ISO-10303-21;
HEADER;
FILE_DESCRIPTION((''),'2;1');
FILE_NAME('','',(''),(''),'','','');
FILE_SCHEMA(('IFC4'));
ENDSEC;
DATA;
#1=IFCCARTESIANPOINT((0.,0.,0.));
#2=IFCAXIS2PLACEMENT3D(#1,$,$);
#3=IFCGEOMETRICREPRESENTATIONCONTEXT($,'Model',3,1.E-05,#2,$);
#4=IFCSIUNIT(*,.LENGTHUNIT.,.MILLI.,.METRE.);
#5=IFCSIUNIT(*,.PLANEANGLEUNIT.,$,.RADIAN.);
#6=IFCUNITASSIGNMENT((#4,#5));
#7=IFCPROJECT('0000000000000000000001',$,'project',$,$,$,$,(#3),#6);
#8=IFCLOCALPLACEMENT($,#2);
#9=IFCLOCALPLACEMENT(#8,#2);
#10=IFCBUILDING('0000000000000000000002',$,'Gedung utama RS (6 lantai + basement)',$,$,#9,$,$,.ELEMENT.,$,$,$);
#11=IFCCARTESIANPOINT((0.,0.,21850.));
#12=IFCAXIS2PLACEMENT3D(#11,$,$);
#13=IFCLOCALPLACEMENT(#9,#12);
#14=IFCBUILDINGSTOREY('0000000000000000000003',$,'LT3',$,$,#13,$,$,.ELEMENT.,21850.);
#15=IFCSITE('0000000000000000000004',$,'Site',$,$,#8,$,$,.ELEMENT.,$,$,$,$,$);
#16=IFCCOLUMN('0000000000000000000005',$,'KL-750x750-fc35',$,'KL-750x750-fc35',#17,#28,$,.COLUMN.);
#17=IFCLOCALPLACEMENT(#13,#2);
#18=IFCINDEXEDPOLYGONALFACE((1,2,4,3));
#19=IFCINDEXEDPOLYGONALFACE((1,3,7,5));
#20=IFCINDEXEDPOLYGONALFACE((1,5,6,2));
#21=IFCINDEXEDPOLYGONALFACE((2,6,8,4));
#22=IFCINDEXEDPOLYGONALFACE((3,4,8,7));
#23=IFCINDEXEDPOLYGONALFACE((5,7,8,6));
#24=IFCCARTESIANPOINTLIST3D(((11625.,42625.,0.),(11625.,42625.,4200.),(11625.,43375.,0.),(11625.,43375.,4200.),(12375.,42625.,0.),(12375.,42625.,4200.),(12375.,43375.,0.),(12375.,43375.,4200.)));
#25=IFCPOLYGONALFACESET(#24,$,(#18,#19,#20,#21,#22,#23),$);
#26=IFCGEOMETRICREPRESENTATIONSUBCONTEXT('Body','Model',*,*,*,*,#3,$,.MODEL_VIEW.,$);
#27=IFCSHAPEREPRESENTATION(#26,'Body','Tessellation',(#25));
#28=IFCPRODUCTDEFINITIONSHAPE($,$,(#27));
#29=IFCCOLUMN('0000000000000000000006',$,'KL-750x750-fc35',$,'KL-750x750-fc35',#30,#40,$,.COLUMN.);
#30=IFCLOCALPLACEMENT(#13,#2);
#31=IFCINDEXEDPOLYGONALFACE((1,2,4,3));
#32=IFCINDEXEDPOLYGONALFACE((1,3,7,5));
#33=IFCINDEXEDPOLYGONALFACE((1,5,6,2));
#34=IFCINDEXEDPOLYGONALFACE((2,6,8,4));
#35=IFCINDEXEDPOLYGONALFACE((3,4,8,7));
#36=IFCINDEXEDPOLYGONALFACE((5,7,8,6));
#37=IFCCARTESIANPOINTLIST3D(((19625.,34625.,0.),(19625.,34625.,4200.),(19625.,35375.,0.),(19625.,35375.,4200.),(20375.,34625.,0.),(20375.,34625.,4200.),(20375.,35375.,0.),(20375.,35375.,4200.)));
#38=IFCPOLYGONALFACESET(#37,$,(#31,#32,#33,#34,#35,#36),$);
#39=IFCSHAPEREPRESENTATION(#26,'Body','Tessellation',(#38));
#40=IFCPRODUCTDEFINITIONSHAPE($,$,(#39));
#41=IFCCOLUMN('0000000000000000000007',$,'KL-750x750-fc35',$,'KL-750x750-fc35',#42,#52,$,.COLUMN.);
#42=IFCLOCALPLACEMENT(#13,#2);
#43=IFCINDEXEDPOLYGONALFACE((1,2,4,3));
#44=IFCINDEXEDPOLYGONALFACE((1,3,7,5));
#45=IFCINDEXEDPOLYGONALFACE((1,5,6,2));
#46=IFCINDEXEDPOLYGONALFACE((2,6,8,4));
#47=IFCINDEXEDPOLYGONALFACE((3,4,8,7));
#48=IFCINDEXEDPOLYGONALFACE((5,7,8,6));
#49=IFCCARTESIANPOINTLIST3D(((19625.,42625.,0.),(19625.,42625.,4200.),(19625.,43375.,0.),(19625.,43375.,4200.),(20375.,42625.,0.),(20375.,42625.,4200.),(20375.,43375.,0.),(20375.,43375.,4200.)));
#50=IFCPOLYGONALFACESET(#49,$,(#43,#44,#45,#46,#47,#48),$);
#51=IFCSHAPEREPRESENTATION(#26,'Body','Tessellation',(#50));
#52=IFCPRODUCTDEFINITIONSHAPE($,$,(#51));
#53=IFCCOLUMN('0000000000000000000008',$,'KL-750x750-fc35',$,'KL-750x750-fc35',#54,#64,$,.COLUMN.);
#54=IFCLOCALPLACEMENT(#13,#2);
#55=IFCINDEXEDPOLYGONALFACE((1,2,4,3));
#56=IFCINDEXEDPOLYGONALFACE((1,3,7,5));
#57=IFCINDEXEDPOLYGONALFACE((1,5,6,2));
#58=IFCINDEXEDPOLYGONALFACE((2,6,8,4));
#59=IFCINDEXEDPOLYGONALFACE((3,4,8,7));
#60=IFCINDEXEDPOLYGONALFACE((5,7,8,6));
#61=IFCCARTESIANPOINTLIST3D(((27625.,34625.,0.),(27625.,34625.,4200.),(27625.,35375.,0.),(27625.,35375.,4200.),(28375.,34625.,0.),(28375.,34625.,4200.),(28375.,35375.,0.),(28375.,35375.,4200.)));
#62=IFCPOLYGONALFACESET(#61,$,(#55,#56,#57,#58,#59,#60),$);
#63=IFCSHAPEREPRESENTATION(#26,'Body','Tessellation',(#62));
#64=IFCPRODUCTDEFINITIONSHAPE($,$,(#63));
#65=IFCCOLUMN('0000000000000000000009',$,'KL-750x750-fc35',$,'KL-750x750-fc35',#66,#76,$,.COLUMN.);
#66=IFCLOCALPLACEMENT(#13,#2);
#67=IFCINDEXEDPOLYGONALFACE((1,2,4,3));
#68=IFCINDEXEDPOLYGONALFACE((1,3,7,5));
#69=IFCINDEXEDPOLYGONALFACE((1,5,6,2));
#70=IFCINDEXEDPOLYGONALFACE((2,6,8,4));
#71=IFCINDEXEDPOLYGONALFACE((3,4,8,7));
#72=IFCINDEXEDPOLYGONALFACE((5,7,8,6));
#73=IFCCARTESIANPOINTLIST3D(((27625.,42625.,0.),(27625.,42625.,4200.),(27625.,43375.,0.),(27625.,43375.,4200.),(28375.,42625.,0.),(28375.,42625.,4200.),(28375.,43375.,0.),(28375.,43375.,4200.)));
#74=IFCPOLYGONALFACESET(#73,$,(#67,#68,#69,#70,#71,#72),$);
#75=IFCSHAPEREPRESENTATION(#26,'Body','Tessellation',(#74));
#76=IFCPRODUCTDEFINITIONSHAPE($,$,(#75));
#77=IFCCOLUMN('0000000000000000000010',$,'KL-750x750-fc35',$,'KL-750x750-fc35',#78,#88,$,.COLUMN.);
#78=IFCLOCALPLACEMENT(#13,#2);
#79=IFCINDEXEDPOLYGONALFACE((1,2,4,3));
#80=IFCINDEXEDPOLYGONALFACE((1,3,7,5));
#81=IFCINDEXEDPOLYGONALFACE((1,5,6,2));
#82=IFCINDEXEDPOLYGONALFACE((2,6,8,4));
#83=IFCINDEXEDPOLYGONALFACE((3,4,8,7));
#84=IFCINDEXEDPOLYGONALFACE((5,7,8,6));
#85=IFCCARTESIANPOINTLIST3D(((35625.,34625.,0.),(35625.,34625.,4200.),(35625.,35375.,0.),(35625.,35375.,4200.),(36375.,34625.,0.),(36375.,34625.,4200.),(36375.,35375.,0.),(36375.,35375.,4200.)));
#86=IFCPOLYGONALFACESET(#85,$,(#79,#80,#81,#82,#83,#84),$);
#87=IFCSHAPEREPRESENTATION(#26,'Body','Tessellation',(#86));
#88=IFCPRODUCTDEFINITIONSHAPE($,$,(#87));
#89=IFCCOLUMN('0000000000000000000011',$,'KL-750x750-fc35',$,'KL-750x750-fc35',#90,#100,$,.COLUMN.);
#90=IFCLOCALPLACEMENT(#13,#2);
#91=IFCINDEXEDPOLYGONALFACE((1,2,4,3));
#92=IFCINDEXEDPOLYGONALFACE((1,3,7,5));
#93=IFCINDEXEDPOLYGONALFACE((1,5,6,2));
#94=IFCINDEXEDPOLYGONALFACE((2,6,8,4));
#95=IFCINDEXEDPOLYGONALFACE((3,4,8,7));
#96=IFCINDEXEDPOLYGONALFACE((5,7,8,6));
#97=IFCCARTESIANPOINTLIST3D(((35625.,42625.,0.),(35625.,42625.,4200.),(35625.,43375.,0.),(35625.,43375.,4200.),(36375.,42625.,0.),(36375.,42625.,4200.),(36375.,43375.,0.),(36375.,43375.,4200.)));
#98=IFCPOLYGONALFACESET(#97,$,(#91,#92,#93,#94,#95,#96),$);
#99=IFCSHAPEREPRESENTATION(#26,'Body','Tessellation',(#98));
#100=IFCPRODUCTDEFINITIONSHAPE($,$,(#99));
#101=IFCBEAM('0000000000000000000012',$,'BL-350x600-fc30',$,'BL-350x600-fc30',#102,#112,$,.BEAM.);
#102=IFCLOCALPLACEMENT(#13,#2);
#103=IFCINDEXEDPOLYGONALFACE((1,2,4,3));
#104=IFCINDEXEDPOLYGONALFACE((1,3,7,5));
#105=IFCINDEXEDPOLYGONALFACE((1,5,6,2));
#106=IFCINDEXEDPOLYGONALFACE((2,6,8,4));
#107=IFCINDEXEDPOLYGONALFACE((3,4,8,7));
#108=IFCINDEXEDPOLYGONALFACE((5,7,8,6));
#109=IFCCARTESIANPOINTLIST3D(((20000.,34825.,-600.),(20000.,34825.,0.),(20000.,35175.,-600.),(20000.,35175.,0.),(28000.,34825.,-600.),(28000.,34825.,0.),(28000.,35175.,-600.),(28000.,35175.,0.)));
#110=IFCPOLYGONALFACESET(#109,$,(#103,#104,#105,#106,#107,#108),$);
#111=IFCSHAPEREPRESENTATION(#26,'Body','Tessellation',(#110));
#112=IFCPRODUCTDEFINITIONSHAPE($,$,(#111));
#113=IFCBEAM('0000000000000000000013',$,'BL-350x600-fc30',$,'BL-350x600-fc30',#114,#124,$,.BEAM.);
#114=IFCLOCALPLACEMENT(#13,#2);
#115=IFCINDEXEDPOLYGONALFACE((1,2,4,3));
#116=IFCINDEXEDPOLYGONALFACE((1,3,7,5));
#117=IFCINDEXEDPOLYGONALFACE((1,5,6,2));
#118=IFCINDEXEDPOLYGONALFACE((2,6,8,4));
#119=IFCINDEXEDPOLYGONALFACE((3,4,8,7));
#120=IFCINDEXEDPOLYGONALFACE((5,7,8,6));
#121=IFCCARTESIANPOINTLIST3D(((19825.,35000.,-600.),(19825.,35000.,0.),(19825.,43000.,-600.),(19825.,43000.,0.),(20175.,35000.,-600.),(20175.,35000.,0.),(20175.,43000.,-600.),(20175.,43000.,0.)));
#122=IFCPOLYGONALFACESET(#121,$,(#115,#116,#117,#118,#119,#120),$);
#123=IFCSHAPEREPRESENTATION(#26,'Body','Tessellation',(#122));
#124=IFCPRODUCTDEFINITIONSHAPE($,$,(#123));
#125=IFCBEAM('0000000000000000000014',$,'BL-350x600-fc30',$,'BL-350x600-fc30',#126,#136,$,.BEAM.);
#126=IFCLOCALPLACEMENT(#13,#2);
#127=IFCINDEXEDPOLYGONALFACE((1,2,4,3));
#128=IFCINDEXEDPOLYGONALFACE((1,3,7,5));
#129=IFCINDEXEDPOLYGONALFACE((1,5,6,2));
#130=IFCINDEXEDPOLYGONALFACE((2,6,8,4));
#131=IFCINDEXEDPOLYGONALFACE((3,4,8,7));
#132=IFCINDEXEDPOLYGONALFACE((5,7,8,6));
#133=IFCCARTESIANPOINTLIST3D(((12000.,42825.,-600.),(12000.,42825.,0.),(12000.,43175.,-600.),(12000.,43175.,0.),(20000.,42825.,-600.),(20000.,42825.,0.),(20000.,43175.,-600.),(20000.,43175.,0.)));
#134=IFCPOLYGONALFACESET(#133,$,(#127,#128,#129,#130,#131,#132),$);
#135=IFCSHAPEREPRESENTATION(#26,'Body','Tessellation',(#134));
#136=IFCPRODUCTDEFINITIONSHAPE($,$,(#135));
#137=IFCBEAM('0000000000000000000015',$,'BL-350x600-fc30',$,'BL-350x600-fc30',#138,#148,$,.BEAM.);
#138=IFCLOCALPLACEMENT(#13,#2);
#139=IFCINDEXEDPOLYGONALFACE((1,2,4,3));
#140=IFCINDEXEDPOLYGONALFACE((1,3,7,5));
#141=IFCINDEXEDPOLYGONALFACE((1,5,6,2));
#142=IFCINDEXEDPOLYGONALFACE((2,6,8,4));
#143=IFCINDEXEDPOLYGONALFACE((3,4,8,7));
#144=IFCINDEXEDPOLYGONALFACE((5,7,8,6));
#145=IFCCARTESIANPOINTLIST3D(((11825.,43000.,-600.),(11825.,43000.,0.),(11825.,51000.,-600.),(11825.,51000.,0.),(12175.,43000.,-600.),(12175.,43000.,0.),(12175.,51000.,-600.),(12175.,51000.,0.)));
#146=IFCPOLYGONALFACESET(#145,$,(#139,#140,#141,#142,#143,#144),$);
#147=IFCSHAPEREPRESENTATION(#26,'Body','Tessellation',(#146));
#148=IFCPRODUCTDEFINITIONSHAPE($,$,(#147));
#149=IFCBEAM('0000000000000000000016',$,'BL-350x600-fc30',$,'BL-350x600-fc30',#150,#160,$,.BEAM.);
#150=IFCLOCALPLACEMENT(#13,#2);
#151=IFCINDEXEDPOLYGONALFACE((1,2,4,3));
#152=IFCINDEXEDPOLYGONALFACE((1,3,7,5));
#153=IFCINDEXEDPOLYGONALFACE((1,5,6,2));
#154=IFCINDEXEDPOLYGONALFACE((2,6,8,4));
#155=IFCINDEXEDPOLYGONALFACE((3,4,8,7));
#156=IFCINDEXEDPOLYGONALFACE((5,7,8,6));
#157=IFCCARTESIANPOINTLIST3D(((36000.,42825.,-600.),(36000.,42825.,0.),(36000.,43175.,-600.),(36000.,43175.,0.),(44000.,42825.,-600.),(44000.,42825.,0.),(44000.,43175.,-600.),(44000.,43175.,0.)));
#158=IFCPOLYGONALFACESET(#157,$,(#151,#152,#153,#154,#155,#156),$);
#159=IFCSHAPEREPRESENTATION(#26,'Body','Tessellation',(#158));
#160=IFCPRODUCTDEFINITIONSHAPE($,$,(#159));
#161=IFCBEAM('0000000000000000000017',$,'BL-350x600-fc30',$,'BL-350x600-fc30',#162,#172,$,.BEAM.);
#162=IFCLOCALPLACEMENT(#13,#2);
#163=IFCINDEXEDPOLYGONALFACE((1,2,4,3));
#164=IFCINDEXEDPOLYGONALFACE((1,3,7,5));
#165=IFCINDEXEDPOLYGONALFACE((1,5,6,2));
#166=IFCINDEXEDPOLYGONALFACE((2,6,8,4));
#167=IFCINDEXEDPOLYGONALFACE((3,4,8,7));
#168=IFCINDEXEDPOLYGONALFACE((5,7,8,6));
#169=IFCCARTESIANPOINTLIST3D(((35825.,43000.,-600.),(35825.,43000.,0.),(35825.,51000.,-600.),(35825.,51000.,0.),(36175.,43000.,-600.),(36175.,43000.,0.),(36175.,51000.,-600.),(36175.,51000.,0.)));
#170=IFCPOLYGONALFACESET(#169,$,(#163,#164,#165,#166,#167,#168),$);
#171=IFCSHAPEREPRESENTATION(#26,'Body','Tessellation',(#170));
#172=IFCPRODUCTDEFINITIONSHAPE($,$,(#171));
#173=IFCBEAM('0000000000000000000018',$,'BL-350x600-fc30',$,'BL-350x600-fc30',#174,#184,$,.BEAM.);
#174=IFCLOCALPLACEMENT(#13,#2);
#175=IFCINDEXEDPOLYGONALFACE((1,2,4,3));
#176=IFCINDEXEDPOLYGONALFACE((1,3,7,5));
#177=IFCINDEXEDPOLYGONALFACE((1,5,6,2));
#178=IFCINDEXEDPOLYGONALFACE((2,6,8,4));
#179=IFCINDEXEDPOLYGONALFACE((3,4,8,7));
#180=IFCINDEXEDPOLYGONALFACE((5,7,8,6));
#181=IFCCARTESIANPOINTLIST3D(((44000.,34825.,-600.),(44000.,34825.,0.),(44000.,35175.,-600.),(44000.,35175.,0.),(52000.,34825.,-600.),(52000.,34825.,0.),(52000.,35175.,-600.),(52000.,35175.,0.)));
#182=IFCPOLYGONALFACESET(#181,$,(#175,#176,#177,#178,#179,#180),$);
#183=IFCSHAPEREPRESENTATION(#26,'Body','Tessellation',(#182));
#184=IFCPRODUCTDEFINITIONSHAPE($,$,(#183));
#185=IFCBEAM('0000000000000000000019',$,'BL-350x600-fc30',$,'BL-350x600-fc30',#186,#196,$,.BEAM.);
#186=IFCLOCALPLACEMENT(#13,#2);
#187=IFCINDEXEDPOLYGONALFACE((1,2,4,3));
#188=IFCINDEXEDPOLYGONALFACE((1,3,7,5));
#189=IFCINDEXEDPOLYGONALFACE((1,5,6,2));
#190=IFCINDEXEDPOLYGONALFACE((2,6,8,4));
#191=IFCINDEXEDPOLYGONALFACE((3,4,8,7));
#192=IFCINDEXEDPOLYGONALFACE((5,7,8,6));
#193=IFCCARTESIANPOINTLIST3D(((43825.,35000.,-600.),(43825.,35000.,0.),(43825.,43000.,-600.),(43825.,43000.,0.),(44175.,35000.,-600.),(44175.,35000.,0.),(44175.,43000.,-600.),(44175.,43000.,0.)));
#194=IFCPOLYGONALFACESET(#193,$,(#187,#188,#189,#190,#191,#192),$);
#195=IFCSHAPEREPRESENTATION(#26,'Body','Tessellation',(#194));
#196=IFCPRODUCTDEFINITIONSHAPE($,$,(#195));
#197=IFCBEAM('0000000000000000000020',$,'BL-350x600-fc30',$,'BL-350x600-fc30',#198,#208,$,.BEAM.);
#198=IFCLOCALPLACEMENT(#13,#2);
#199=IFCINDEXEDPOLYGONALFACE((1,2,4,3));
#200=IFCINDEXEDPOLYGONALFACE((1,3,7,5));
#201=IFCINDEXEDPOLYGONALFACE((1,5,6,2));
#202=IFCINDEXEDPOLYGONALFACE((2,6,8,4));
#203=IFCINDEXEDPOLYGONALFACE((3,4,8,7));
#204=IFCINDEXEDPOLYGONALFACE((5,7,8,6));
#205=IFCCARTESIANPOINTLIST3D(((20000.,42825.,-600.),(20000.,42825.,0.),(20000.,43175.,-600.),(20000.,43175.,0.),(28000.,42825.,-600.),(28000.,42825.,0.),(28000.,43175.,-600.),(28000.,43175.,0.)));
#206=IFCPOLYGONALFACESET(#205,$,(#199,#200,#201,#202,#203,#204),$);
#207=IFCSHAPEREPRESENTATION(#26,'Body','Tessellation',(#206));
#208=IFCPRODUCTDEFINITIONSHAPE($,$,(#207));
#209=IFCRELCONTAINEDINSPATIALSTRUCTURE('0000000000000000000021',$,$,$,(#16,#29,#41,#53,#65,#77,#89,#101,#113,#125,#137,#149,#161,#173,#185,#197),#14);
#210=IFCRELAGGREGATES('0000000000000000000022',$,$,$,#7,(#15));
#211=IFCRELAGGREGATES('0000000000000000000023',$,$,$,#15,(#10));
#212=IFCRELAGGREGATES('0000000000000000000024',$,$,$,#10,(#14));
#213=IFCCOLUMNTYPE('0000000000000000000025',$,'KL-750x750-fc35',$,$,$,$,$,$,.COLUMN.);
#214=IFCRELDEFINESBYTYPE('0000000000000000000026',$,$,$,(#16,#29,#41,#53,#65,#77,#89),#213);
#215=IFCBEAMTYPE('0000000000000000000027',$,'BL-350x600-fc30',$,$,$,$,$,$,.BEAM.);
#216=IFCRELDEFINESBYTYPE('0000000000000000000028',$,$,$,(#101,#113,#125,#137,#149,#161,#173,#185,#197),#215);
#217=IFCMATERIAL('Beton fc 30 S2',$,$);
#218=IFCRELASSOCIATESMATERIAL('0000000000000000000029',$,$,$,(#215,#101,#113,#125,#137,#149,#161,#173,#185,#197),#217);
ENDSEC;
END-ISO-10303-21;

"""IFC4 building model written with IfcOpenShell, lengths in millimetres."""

from ifc_helpers import new_model, si_unit, frame, origin, origin_2d, place, context, subcontext, project, spatial, rectangle, extrude, material, material_profile, profile_set, profile_usage, type_object, element, save


model = new_model("IFC4")

# Units and contexts
model_context = context("Model", 3, precision=1e-05, world=origin())
body_context = subcontext(model_context, "Body", "Model", "MODEL_VIEW")
ifc_project = project(units=[si_unit("LENGTHUNIT", "METRE", prefix="MILLI"), si_unit("PLANEANGLEUNIT", "RADIAN")], contexts=[model_context])

# Site, building, storey
site_placement = place(None, origin())
site = spatial("IfcSite", under=ifc_project, at=site_placement, Name="Site", CompositionType="ELEMENT")
building_placement = place(site_placement, origin())
building = spatial("IfcBuilding", under=site, at=building_placement, Name="Gedung utama RS (6 lantai + basement)", CompositionType="ELEMENT")
storey_placement = place(building_placement, frame((0.0, 0.0, 21850.0)))
storey = spatial("IfcBuildingStorey", under=building, at=storey_placement, Name="LT3", CompositionType="ELEMENT", Elevation=21850.0)

# Columns
ifc_material_profile_1 = material_profile(None, rectangle(XDim=750.0, YDim=750.0, at=origin_2d()), Name="KL-750x750-fc35")
ifc_profile_set_1 = profile_set([ifc_material_profile_1], Name="KL-750x750-fc35")
ifc_profile_usage_1 = profile_usage(ifc_profile_set_1, cardinal=5)
column_type = type_object("IfcColumnType", Name="KL-750x750-fc35", PredefinedType="COLUMN", material=ifc_profile_set_1)
for number, where, z_axis, x_axis, name in (
    (1, (12000.0, 43000.0, 0.0), (0.0, 0.0, 1.0), (1.0, 0.0, 0.0), "KL-750x750-fc35"),
    (2, (20000.0, 35000.0, 0.0), (0.0, 0.0, 1.0), (1.0, 0.0, 0.0), "KL-750x750-fc35"),
    (3, (20000.0, 43000.0, 0.0), (0.0, 0.0, 1.0), (1.0, 0.0, 0.0), "KL-750x750-fc35"),
    (4, (28000.0, 35000.0, 0.0), (0.0, 0.0, 1.0), (1.0, 0.0, 0.0), "KL-750x750-fc35"),
    (5, (28000.0, 43000.0, 0.0), (0.0, 0.0, 1.0), (1.0, 0.0, 0.0), "KL-750x750-fc35"),
    (6, (36000.0, 35000.0, 0.0), (0.0, 0.0, 1.0), (1.0, 0.0, 0.0), "KL-750x750-fc35"),
    (7, (36000.0, 43000.0, 0.0), (0.0, 0.0, 1.0), (1.0, 0.0, 0.0), "KL-750x750-fc35"),
):
    element("IfcColumn", number, at=place(storey_placement, frame(where, z_axis=z_axis, x_axis=x_axis)), inside=storey, type_object=column_type, material=ifc_profile_usage_1, Name=name, ObjectType="KL-750x750-fc35", PredefinedType="COLUMN", context=body_context, shape_type="SweptSolid", body=[
        extrude(rectangle(XDim=750.0, YDim=750.0, at=origin_2d()), origin(), (0.0, 0.0, 1.0), 4200.0),
    ])

# Beams
ifc_material_1 = material(Name="Beton fc 30 S2")
ifc_material_profile_2 = material_profile(ifc_material_1, rectangle(XDim=350.0, YDim=600.0, at=origin_2d()), Name="BL-350x600-fc30")
ifc_profile_set_2 = profile_set([ifc_material_profile_2], Name="BL-350x600-fc30")
ifc_profile_usage_2 = profile_usage(ifc_profile_set_2, cardinal=8)
beam_type = type_object("IfcBeamType", Name="BL-350x600-fc30", PredefinedType="BEAM", material=ifc_profile_set_2)
beam_1_placement = place(storey_placement, frame((20000.0, 35000.0, -300.0)))
element("IfcBeam", 8, at=beam_1_placement, inside=storey, type_object=beam_type, material=ifc_profile_usage_2, Name="BL-350x600-fc30", ObjectType="BL-350x600-fc30", PredefinedType="BEAM", context=body_context, shape_type="SweptSolid", body=[
    extrude(rectangle(XDim=350.0, YDim=600.0, at=origin_2d()), frame((0.0, 0.0, 0.0), z_axis=(1.0, 0.0, 0.0), x_axis=(0.0, 1.0, 0.0)), (0.0, 0.0, 1.0), 8000.0),
])
beam_2_placement = place(storey_placement, frame((20000.0, 35000.0, -300.0)))
element("IfcBeam", 9, at=beam_2_placement, inside=storey, type_object=beam_type, material=ifc_profile_usage_2, Name="BL-350x600-fc30", ObjectType="BL-350x600-fc30", PredefinedType="BEAM", context=body_context, shape_type="SweptSolid", body=[
    extrude(rectangle(XDim=350.0, YDim=600.0, at=origin_2d()), frame((0.0, 0.0, 0.0), z_axis=(0.0, 1.0, 0.0), x_axis=(-1.0, 0.0, 0.0)), (0.0, 0.0, 1.0), 8000.0),
])
beam_3_placement = place(storey_placement, frame((12000.0, 43000.0, -300.0)))
element("IfcBeam", 10, at=beam_3_placement, inside=storey, type_object=beam_type, material=ifc_profile_usage_2, Name="BL-350x600-fc30", ObjectType="BL-350x600-fc30", PredefinedType="BEAM", context=body_context, shape_type="SweptSolid", body=[
    extrude(rectangle(XDim=350.0, YDim=600.0, at=origin_2d()), frame((0.0, 0.0, 0.0), z_axis=(1.0, 0.0, 0.0), x_axis=(0.0, 1.0, 0.0)), (0.0, 0.0, 1.0), 8000.0),
])
beam_4_placement = place(storey_placement, frame((12000.0, 43000.0, -300.0)))
element("IfcBeam", 11, at=beam_4_placement, inside=storey, type_object=beam_type, material=ifc_profile_usage_2, Name="BL-350x600-fc30", ObjectType="BL-350x600-fc30", PredefinedType="BEAM", context=body_context, shape_type="SweptSolid", body=[
    extrude(rectangle(XDim=350.0, YDim=600.0, at=origin_2d()), frame((0.0, 0.0, 0.0), z_axis=(0.0, 1.0, 0.0), x_axis=(-1.0, 0.0, 0.0)), (0.0, 0.0, 1.0), 8000.0),
])
beam_5_placement = place(storey_placement, frame((36000.0, 43000.0, -300.0)))
element("IfcBeam", 12, at=beam_5_placement, inside=storey, type_object=beam_type, material=ifc_profile_usage_2, Name="BL-350x600-fc30", ObjectType="BL-350x600-fc30", PredefinedType="BEAM", context=body_context, shape_type="SweptSolid", body=[
    extrude(rectangle(XDim=350.0, YDim=600.0, at=origin_2d()), frame((0.0, 0.0, 0.0), z_axis=(1.0, 0.0, 0.0), x_axis=(0.0, 1.0, 0.0)), (0.0, 0.0, 1.0), 8000.0),
])
beam_6_placement = place(storey_placement, frame((36000.0, 43000.0, -300.0)))
element("IfcBeam", 13, at=beam_6_placement, inside=storey, type_object=beam_type, material=ifc_profile_usage_2, Name="BL-350x600-fc30", ObjectType="BL-350x600-fc30", PredefinedType="BEAM", context=body_context, shape_type="SweptSolid", body=[
    extrude(rectangle(XDim=350.0, YDim=600.0, at=origin_2d()), frame((0.0, 0.0, 0.0), z_axis=(0.0, 1.0, 0.0), x_axis=(-1.0, 0.0, 0.0)), (0.0, 0.0, 1.0), 8000.0),
])
beam_7_placement = place(storey_placement, frame((44000.0, 35000.0, -300.0)))
element("IfcBeam", 14, at=beam_7_placement, inside=storey, type_object=beam_type, material=ifc_profile_usage_2, Name="BL-350x600-fc30", ObjectType="BL-350x600-fc30", PredefinedType="BEAM", context=body_context, shape_type="SweptSolid", body=[
    extrude(rectangle(XDim=350.0, YDim=600.0, at=origin_2d()), frame((0.0, 0.0, 0.0), z_axis=(1.0, 0.0, 0.0), x_axis=(0.0, 1.0, 0.0)), (0.0, 0.0, 1.0), 8000.0),
])
beam_8_placement = place(storey_placement, frame((44000.0, 35000.0, -300.0)))
element("IfcBeam", 15, at=beam_8_placement, inside=storey, type_object=beam_type, material=ifc_profile_usage_2, Name="BL-350x600-fc30", ObjectType="BL-350x600-fc30", PredefinedType="BEAM", context=body_context, shape_type="SweptSolid", body=[
    extrude(rectangle(XDim=350.0, YDim=600.0, at=origin_2d()), frame((0.0, 0.0, 0.0), z_axis=(0.0, 1.0, 0.0), x_axis=(-1.0, 0.0, 0.0)), (0.0, 0.0, 1.0), 8000.0),
])
beam_9_placement = place(storey_placement, frame((20000.0, 43000.0, -300.0)))
element("IfcBeam", 16, at=beam_9_placement, inside=storey, type_object=beam_type, material=ifc_profile_usage_2, Name="BL-350x600-fc30", ObjectType="BL-350x600-fc30", PredefinedType="BEAM", context=body_context, shape_type="SweptSolid", body=[
    extrude(rectangle(XDim=350.0, YDim=600.0, at=origin_2d()), frame((0.0, 0.0, 0.0), z_axis=(1.0, 0.0, 0.0), x_axis=(0.0, 1.0, 0.0)), (0.0, 0.0, 1.0), 8000.0),
])

save(model, "model.ifc")
